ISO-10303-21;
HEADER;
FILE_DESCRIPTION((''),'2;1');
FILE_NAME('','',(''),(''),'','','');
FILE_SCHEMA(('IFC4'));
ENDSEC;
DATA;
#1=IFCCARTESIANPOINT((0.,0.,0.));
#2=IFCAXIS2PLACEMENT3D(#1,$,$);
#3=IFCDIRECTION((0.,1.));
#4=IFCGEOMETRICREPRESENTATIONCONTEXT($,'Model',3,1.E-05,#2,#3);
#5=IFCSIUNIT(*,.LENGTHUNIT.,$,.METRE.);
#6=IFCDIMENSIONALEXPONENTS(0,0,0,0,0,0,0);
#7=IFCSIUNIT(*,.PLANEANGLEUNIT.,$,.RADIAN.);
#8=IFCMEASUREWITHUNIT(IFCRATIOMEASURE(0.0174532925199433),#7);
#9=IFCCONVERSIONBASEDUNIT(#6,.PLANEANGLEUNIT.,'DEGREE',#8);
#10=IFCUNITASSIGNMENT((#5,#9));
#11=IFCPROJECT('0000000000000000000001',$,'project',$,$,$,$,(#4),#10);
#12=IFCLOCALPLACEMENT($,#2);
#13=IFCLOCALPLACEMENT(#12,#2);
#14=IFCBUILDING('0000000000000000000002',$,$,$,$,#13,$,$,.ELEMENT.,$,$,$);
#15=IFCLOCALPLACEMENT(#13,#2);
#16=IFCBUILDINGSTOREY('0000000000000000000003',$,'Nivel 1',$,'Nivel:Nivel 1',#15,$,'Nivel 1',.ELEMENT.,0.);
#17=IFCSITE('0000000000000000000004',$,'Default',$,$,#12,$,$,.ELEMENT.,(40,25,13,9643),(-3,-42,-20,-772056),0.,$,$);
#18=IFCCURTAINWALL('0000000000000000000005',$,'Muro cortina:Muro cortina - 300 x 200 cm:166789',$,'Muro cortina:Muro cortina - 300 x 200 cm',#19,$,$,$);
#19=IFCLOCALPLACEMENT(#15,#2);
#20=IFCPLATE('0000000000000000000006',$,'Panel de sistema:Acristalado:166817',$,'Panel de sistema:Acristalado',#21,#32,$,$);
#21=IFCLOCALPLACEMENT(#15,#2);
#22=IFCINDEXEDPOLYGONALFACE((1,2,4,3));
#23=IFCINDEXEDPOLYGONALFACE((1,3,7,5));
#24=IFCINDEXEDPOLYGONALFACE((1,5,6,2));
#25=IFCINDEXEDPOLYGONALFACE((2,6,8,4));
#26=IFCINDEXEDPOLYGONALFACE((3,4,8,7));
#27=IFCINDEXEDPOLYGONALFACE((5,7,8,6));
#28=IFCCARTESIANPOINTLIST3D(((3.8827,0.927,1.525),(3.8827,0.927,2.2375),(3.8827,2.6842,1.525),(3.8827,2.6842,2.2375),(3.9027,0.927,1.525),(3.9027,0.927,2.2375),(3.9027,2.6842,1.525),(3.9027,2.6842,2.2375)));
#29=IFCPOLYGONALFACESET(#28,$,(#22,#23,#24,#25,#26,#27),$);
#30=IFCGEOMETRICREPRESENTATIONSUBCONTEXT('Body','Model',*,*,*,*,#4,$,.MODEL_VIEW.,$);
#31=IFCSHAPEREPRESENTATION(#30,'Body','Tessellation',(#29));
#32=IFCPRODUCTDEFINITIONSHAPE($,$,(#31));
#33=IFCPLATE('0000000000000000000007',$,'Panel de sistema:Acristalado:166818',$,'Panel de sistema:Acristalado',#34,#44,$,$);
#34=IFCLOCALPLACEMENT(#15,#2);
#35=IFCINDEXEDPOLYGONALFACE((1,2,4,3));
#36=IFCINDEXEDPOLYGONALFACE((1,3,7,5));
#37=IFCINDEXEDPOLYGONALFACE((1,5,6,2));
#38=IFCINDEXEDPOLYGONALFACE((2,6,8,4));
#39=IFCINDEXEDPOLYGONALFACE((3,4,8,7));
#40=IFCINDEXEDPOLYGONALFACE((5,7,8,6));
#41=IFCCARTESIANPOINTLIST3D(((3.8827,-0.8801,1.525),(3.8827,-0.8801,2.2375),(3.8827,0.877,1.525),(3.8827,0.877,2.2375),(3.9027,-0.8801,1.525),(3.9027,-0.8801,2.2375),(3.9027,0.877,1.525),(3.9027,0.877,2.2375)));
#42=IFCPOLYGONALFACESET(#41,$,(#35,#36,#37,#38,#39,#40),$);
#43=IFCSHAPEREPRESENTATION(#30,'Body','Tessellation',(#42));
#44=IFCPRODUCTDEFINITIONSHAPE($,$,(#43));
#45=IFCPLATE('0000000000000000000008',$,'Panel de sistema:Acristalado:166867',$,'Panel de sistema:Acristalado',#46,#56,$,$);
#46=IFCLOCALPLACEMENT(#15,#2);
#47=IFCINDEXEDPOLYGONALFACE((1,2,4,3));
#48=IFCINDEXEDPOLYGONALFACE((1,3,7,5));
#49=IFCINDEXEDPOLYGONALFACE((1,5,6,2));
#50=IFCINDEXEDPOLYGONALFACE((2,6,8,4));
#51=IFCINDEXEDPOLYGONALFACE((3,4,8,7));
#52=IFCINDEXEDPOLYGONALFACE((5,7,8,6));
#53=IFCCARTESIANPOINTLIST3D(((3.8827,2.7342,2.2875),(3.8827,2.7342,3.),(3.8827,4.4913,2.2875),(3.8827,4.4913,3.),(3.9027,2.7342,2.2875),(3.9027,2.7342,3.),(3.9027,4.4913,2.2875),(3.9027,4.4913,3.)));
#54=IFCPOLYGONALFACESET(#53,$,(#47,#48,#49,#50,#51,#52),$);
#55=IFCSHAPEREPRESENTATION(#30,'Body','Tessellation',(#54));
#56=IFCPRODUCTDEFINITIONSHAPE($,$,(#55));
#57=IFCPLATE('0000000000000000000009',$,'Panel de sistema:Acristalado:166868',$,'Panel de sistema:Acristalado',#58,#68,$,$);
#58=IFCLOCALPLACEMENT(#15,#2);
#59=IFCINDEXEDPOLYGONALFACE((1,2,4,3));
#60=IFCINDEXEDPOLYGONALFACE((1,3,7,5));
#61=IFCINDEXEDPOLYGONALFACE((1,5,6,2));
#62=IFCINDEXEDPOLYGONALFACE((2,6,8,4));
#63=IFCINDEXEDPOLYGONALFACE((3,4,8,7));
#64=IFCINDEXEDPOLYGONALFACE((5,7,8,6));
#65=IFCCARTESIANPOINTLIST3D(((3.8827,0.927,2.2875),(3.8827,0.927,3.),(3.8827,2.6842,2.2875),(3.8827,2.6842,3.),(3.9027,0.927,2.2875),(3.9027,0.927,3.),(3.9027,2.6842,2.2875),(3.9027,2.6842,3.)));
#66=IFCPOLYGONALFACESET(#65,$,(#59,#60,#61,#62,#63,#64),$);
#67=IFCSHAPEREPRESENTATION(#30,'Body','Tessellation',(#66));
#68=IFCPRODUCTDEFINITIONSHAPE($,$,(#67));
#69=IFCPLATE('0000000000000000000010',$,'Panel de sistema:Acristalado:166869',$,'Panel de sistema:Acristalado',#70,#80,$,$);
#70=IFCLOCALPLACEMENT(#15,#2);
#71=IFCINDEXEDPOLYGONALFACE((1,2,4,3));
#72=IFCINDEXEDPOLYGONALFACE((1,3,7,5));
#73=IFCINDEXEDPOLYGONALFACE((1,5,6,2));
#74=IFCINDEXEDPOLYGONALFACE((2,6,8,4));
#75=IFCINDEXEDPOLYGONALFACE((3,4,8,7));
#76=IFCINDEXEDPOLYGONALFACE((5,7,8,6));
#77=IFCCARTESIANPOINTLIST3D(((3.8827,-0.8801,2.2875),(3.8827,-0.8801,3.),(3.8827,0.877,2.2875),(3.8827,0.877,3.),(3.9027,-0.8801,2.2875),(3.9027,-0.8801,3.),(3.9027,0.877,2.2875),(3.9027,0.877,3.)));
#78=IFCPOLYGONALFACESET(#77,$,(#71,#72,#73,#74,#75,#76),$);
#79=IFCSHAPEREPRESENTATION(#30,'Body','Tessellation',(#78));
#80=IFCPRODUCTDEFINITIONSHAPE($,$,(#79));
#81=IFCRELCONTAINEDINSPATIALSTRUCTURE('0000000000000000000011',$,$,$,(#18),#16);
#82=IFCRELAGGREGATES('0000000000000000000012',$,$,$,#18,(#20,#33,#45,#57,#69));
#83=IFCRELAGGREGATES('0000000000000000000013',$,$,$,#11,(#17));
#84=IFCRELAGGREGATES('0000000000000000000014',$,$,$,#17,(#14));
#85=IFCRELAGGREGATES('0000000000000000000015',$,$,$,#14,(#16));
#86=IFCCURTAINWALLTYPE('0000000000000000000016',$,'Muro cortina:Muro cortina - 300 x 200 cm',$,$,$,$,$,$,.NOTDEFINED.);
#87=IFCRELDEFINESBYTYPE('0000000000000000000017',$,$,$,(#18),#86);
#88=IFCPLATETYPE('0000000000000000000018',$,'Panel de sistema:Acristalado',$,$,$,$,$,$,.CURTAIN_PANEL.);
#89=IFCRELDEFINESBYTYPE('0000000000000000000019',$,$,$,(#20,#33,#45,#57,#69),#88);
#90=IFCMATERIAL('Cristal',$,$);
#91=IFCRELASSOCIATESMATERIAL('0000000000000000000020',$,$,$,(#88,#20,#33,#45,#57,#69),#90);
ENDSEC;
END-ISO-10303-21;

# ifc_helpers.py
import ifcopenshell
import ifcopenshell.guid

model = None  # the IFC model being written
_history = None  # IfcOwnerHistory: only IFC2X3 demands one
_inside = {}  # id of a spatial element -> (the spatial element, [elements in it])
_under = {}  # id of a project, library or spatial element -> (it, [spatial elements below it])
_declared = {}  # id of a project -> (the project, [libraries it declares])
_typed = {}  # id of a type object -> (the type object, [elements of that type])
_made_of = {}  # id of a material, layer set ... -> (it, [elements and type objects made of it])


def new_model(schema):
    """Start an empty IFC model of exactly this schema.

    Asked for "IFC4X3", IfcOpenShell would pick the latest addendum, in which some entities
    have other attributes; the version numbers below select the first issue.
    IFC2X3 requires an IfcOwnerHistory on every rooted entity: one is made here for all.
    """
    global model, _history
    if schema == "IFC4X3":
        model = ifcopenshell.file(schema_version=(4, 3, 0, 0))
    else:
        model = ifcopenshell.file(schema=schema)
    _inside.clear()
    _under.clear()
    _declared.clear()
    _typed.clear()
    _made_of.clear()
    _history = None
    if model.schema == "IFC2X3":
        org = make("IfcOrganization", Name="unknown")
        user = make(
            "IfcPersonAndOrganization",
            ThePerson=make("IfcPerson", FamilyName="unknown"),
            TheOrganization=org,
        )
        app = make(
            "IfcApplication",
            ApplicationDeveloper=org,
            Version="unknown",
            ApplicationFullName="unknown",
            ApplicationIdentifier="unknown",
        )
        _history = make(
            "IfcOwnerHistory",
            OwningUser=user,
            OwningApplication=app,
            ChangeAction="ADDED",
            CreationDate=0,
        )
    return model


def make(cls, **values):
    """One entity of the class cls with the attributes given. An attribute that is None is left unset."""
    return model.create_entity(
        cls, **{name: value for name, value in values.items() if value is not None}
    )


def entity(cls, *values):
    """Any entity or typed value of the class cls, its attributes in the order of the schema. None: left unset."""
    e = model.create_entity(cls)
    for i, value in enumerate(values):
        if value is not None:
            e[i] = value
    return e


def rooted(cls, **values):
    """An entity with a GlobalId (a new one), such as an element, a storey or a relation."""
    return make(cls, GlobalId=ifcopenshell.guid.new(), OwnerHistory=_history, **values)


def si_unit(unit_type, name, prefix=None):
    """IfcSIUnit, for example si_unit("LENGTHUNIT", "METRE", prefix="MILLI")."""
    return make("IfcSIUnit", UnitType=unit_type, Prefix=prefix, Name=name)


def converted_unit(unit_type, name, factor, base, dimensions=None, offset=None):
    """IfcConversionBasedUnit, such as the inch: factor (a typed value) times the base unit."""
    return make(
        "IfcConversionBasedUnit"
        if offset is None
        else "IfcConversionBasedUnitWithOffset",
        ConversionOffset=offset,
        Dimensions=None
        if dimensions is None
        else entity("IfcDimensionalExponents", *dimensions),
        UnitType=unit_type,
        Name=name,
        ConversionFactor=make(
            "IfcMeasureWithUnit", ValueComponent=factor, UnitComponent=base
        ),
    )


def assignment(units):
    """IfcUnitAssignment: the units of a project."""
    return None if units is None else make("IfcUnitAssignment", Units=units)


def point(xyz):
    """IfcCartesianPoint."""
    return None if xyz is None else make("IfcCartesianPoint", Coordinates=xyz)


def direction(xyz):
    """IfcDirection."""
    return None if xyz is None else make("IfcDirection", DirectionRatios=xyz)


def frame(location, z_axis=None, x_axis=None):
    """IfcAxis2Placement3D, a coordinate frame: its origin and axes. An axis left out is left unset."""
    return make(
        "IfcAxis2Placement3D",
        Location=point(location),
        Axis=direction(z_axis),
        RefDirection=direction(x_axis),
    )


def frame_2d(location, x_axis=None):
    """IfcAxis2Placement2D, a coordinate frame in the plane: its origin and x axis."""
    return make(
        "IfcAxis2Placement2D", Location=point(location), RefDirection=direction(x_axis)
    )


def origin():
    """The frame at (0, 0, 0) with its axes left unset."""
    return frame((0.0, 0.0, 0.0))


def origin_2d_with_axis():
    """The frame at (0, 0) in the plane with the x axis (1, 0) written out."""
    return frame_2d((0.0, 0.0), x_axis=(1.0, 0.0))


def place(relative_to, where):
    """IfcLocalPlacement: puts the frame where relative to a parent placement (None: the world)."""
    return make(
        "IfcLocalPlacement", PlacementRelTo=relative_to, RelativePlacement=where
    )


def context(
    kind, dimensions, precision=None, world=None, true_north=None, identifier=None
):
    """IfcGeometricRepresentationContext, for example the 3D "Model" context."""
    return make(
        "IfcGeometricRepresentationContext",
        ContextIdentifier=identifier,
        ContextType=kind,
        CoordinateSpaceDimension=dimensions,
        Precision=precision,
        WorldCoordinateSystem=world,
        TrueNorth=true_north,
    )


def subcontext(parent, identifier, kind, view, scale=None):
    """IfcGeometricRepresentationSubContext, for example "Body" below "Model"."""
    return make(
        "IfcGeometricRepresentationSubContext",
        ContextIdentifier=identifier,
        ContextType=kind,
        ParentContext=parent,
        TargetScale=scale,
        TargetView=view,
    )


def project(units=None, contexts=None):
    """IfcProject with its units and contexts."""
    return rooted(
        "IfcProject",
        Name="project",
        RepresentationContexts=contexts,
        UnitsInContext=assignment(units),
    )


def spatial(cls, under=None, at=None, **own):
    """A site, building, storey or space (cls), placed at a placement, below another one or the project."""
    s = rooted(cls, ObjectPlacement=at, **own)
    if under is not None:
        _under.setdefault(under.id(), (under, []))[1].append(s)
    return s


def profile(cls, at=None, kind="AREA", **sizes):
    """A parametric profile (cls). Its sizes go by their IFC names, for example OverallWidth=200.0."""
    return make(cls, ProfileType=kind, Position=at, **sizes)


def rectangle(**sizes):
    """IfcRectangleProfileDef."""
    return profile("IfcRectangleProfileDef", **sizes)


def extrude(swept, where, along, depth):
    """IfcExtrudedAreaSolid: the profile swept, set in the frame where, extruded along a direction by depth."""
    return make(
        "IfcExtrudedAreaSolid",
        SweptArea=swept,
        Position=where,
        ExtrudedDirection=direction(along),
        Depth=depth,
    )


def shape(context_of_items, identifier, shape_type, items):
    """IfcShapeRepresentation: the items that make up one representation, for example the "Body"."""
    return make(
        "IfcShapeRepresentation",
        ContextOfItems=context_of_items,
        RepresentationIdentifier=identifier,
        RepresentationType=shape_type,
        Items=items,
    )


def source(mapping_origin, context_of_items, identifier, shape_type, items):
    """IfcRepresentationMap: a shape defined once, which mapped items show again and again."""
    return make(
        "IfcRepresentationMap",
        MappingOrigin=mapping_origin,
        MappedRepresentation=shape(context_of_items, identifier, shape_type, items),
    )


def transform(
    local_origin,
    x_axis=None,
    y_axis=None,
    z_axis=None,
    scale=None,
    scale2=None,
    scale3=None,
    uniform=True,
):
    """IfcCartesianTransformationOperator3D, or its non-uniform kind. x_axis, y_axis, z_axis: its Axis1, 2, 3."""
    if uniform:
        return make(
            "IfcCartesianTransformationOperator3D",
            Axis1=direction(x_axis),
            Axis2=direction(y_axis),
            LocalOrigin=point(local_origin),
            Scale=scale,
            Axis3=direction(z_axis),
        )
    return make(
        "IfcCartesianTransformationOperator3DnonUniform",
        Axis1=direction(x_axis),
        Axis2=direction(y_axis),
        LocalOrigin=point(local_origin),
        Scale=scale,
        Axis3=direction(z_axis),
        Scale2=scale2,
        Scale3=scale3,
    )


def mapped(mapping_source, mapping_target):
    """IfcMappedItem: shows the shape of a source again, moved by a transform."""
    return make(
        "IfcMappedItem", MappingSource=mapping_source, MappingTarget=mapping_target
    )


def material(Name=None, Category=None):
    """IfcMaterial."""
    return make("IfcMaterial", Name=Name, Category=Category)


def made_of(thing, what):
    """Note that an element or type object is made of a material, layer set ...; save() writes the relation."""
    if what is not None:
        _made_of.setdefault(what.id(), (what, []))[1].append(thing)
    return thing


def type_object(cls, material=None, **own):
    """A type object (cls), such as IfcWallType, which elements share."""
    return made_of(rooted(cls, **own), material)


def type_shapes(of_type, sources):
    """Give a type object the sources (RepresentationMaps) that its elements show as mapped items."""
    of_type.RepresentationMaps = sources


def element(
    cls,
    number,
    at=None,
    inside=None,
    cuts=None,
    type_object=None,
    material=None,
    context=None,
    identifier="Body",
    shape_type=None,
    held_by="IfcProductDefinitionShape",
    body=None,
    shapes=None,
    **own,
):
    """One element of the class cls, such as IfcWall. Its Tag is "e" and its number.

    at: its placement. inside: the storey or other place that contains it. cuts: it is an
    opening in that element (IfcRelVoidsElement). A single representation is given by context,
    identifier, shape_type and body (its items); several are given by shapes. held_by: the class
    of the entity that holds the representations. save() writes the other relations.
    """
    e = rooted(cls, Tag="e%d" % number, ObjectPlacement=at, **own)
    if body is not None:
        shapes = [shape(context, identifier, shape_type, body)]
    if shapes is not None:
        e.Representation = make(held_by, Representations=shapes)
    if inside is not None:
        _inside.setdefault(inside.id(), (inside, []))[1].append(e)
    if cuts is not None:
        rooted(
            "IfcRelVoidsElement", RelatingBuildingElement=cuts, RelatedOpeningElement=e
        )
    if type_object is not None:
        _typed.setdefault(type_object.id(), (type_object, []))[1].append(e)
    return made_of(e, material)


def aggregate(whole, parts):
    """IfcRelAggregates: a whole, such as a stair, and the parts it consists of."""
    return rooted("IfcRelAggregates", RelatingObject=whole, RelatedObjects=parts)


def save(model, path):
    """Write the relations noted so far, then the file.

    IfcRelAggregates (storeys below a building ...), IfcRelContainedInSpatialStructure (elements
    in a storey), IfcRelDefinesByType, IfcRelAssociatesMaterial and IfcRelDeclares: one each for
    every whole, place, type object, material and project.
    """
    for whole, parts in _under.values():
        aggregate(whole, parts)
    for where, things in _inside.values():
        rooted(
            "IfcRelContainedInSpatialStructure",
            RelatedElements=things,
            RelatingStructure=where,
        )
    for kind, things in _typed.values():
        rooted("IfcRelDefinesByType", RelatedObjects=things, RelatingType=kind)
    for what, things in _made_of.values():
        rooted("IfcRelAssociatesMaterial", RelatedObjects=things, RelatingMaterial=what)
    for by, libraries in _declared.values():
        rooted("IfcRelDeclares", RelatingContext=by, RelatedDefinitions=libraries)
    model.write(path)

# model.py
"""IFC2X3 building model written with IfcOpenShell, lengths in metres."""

from ifc_helpers import new_model, entity, si_unit, converted_unit, direction, frame, origin, origin_2d_with_axis, place, context, subcontext, project, spatial, rectangle, extrude, source, transform, mapped, material, type_object, type_shapes, element, aggregate, save


model = new_model("IFC2X3")

# Units and contexts
model_context = context("Model", 3, precision=1e-05, world=origin(), true_north=direction((0.0, 1.0)))
body_context = subcontext(model_context, "Body", "Model", "MODEL_VIEW")
ifc_project = project(units=[si_unit("LENGTHUNIT", "METRE"), converted_unit("PLANEANGLEUNIT", "DEGREE", entity("IfcRatioMeasure", 0.0174532925199433), si_unit("PLANEANGLEUNIT", "RADIAN"), dimensions=[0, 0, 0, 0, 0, 0, 0])], contexts=[model_context])

# Site, building, storey
site_placement = place(None, origin())
site = spatial("IfcSite", under=ifc_project, at=site_placement, Name="Default", CompositionType="ELEMENT", RefLatitude=(40, 25, 13, 9643), RefLongitude=(-3, -42, -20, -772056), RefElevation=0.0)
building_placement = place(site_placement, origin())
building = spatial("IfcBuilding", under=site, at=building_placement, CompositionType="ELEMENT")
storey_placement = place(building_placement, origin())
storey = spatial("IfcBuildingStorey", under=building, at=storey_placement, Name="Nivel 1", ObjectType="Nivel:Nivel 1", LongName="Nivel 1", CompositionType="ELEMENT", Elevation=0.0)

# Curtain wall, plates
curtain_wall_type = type_object("IfcCurtainWallType", Name="Muro cortina:Muro cortina - 300 x 200 cm", PredefinedType="NOTDEFINED")
curtain_wall_placement = place(storey_placement, origin())
curtain_wall = element("IfcCurtainWall", 1, at=curtain_wall_placement, inside=storey, type_object=curtain_wall_type, Name="Muro cortina:Muro cortina - 300 x 200 cm:166789", ObjectType="Muro cortina:Muro cortina - 300 x 200 cm")
ifc_material_1 = material(Name="Cristal")
plate_type = type_object("IfcPlateType", Name="Panel de sistema:Acristalado", PredefinedType="CURTAIN_PANEL", material=ifc_material_1)
shared_shape_1 = source(origin(), body_context, "Body", "SweptSolid", [
    extrude(rectangle(XDim=0.02, YDim=1.7571, at=origin_2d_with_axis()), frame((0.0, 0.0, 0.0), z_axis=(0.0, 0.0, 1.0), x_axis=(0.0, 1.0, 0.0)), (0.0, 0.0, 1.0), 0.7125),
])
type_shapes(plate_type, [shared_shape_1])
plate_1_placement = place(curtain_wall_placement, frame((3.8927, 1.8056, 1.525), z_axis=(0.0, 0.0, 1.0), x_axis=(0.0, -1.0, 0.0)))
plate_1 = element("IfcPlate", 2, at=plate_1_placement, type_object=plate_type, material=ifc_material_1, Name="Panel de sistema:Acristalado:166817", ObjectType="Panel de sistema:Acristalado", context=body_context, shape_type="MappedRepresentation", body=[
    mapped(shared_shape_1, transform((0.0, 0.0, 0.0), scale=1.0)),
])
plate_2_placement = place(curtain_wall_placement, frame((3.8927, -0.0015, 1.525), z_axis=(0.0, 0.0, 1.0), x_axis=(0.0, -1.0, 0.0)))
plate_2 = element("IfcPlate", 3, at=plate_2_placement, type_object=plate_type, material=ifc_material_1, Name="Panel de sistema:Acristalado:166818", ObjectType="Panel de sistema:Acristalado", context=body_context, shape_type="MappedRepresentation", body=[
    mapped(shared_shape_1, transform((0.0, 0.0, 0.0), scale=1.0)),
])
plate_3_placement = place(curtain_wall_placement, frame((3.8927, 3.6127, 2.2875), z_axis=(0.0, 0.0, 1.0), x_axis=(0.0, -1.0, 0.0)))
plate_3 = element("IfcPlate", 4, at=plate_3_placement, type_object=plate_type, material=ifc_material_1, Name="Panel de sistema:Acristalado:166867", ObjectType="Panel de sistema:Acristalado", context=body_context, shape_type="MappedRepresentation", body=[
    mapped(shared_shape_1, transform((0.0, 0.0, 0.0), scale=1.0)),
])
plate_4_placement = place(curtain_wall_placement, frame((3.8927, 1.8056, 2.2875), z_axis=(0.0, 0.0, 1.0), x_axis=(0.0, -1.0, 0.0)))
plate_4 = element("IfcPlate", 5, at=plate_4_placement, type_object=plate_type, material=ifc_material_1, Name="Panel de sistema:Acristalado:166868", ObjectType="Panel de sistema:Acristalado", context=body_context, shape_type="MappedRepresentation", body=[
    mapped(shared_shape_1, transform((0.0, 0.0, 0.0), scale=1.0)),
])
plate_5_placement = place(curtain_wall_placement, frame((3.8927, -0.0015, 2.2875), z_axis=(0.0, 0.0, 1.0), x_axis=(0.0, -1.0, 0.0)))
plate_5 = element("IfcPlate", 6, at=plate_5_placement, type_object=plate_type, material=ifc_material_1, Name="Panel de sistema:Acristalado:166869", ObjectType="Panel de sistema:Acristalado", context=body_context, shape_type="MappedRepresentation", body=[
    mapped(shared_shape_1, transform((0.0, 0.0, 0.0), scale=1.0)),
])
aggregate(curtain_wall, [plate_1, plate_2, plate_3, plate_4, plate_5])

save(model, "model.ifc")
